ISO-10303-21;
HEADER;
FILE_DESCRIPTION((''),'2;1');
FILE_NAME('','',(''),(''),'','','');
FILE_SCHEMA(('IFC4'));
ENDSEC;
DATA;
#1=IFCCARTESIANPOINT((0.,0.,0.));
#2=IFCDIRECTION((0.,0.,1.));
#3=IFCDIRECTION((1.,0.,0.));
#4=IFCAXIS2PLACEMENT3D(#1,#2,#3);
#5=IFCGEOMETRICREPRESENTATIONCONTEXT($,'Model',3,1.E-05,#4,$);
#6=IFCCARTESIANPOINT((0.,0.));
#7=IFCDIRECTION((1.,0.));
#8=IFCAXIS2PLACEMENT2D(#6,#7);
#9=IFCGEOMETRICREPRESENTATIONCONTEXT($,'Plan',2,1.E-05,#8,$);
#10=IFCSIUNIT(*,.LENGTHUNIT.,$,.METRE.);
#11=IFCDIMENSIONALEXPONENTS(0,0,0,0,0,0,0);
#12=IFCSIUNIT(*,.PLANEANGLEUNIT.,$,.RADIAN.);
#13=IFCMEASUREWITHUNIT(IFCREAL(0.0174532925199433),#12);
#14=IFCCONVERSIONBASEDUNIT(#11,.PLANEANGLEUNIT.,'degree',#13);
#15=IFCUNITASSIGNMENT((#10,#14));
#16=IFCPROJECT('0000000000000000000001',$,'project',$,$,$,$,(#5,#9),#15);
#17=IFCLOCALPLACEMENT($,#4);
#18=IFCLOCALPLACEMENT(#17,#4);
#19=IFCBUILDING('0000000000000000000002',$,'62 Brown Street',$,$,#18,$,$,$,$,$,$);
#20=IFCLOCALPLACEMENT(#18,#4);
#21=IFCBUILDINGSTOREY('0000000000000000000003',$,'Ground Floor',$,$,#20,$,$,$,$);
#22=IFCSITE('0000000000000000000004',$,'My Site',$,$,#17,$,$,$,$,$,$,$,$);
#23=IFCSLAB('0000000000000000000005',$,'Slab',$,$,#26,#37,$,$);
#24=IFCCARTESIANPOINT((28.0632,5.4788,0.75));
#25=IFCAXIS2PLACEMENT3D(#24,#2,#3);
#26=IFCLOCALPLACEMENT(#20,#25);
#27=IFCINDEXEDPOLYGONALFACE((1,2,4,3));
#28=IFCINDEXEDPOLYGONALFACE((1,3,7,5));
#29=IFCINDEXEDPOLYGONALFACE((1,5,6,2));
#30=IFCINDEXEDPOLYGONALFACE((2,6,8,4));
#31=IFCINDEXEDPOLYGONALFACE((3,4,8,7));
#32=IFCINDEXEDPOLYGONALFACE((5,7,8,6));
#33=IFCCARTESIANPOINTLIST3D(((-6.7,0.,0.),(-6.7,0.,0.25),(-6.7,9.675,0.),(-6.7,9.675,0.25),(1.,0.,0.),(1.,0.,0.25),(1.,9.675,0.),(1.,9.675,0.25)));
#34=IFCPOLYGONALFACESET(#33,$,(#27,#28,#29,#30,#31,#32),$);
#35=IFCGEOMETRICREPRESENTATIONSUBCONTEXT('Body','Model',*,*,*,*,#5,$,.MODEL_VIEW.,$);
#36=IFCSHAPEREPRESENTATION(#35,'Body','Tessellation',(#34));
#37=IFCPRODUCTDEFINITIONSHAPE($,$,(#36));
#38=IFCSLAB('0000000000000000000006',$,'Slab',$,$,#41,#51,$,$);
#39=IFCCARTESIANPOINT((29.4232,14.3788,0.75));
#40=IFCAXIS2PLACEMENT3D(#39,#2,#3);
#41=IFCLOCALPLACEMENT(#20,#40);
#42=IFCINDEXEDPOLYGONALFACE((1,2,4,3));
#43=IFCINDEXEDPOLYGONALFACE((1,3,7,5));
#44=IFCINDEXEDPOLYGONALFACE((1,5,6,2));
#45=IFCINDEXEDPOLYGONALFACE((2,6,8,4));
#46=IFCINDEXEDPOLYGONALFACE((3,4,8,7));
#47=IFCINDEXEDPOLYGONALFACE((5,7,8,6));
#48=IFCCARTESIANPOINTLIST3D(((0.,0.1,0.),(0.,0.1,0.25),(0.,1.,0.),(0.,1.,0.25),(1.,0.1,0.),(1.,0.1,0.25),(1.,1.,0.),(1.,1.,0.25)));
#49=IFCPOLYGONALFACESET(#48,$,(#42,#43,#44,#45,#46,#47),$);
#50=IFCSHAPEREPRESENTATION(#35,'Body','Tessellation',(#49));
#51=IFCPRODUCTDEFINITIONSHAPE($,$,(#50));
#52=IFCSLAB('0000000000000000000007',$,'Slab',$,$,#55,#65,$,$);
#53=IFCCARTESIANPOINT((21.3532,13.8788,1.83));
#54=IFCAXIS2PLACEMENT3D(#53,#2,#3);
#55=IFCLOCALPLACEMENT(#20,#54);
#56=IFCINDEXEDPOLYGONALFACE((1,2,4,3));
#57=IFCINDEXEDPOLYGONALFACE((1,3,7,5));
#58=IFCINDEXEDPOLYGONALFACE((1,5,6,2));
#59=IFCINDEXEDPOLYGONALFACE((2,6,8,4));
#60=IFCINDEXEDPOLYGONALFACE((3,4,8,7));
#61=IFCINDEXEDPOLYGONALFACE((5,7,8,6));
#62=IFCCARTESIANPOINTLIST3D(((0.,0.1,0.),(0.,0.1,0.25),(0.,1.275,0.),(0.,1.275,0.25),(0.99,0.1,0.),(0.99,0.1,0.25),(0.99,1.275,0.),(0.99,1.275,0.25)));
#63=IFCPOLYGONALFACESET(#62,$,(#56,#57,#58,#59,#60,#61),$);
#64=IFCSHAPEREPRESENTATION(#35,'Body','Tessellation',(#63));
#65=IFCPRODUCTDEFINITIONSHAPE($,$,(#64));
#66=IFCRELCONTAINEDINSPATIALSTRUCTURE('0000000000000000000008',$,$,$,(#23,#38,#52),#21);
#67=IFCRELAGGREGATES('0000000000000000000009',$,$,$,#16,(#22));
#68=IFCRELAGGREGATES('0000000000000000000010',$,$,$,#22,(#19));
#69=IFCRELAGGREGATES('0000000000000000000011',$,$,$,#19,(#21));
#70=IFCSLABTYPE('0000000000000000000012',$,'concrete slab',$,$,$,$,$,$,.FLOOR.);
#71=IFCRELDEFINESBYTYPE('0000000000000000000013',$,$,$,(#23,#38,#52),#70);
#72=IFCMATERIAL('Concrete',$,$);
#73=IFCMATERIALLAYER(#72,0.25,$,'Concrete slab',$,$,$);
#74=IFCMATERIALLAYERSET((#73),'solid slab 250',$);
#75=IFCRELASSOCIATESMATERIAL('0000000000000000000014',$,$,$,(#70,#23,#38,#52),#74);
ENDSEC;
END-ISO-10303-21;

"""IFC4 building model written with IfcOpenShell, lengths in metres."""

from ifc_helpers import new_model, entity, si_unit, converted_unit, frame, origin_with_axes, origin_2d_with_axis, place, context, subcontext, project, spatial, line, indexed_curve, outline, extrude, material, layer, layer_set, layer_usage, type_object, element, save


model = new_model("IFC4")

# Units and contexts
model_context = context("Model", 3, precision=1e-05, world=origin_with_axes())
plan_context = context("Plan", 2, precision=1e-05, world=origin_2d_with_axis())
body_context_1 = subcontext(model_context, "Body", "Model", "MODEL_VIEW")
ifc_project = project(units=[si_unit("LENGTHUNIT", "METRE"), converted_unit("PLANEANGLEUNIT", "degree", entity("IfcReal", 0.0174532925199433), si_unit("PLANEANGLEUNIT", "RADIAN"), dimensions=[0, 0, 0, 0, 0, 0, 0])], contexts=[model_context, plan_context])

# Site, building, storey
site_placement = place(None, origin_with_axes())
site = spatial("IfcSite", under=ifc_project, at=site_placement, Name="My Site")
building_placement = place(site_placement, origin_with_axes())
building = spatial("IfcBuilding", under=site, at=building_placement, Name="62 Brown Street")
storey_placement = place(building_placement, origin_with_axes())
storey = spatial("IfcBuildingStorey", under=building, at=storey_placement, Name="Ground Floor")

# Slabs
ifc_material_1 = material(Name="Concrete")
ifc_layer_1 = layer(ifc_material_1, 0.25, Name="Concrete slab")
ifc_layer_set_1 = layer_set([ifc_layer_1], Name="solid slab 250")
slab_type = type_object("IfcSlabType", Name="concrete slab", PredefinedType="FLOOR", material=ifc_layer_set_1)
ifc_layer_usage_1 = layer_usage(ifc_layer_set_1, "AXIS3", "POSITIVE", 0.0)
slab_1_placement = place(storey_placement, frame((28.0632, 5.4788, 0.75), z_axis=(0.0, 0.0, 1.0), x_axis=(1.0, 0.0, 0.0)))
element("IfcSlab", 1, at=slab_1_placement, inside=storey, type_object=slab_type, material=ifc_layer_usage_1, Name="Slab", context=body_context_1, shape_type="SweptSolid", body=[
    extrude(outline(indexed_curve([(1.0, 9.675), (-6.7, 9.675), (-6.7, 0.0), (1.0, 0.0)], segments=[line(3, 2), line(2, 1), line(1, 4), line(4, 3)], self_intersect=False)), None, (0.0, 0.0, 1.0), 0.25),
])
ifc_layer_usage_2 = layer_usage(ifc_layer_set_1, "AXIS3", "POSITIVE", 0.0)
slab_2_placement = place(storey_placement, frame((29.4232, 14.3788, 0.75), z_axis=(0.0, 0.0, 1.0), x_axis=(1.0, 0.0, 0.0)))
element("IfcSlab", 2, at=slab_2_placement, inside=storey, type_object=slab_type, material=ifc_layer_usage_2, Name="Slab", context=body_context_1, shape_type="SweptSolid", body=[
    extrude(outline(indexed_curve([(1.0, 1.0), (1.0, 0.1), (0.0, 0.1), (0.0, 1.0)], segments=[line(3, 2), line(2, 1), line(1, 4), line(4, 3)], self_intersect=False)), None, (0.0, 0.0, 1.0), 0.25),
])
ifc_layer_usage_3 = layer_usage(ifc_layer_set_1, "AXIS3", "POSITIVE", 0.0)
slab_3_placement = place(storey_placement, frame((21.3532, 13.8788, 1.83), z_axis=(0.0, 0.0, 1.0), x_axis=(1.0, 0.0, 0.0)))
element("IfcSlab", 3, at=slab_3_placement, inside=storey, type_object=slab_type, material=ifc_layer_usage_3, Name="Slab", context=body_context_1, shape_type="SweptSolid", body=[
    extrude(outline(indexed_curve([(0.99, 1.275), (0.99, 0.1), (0.0, 0.1), (0.0, 1.275)], segments=[line(3, 2), line(2, 1), line(1, 4), line(4, 3)], self_intersect=False)), None, (0.0, 0.0, 1.0), 0.25),
])

save(model, "model.ifc")
